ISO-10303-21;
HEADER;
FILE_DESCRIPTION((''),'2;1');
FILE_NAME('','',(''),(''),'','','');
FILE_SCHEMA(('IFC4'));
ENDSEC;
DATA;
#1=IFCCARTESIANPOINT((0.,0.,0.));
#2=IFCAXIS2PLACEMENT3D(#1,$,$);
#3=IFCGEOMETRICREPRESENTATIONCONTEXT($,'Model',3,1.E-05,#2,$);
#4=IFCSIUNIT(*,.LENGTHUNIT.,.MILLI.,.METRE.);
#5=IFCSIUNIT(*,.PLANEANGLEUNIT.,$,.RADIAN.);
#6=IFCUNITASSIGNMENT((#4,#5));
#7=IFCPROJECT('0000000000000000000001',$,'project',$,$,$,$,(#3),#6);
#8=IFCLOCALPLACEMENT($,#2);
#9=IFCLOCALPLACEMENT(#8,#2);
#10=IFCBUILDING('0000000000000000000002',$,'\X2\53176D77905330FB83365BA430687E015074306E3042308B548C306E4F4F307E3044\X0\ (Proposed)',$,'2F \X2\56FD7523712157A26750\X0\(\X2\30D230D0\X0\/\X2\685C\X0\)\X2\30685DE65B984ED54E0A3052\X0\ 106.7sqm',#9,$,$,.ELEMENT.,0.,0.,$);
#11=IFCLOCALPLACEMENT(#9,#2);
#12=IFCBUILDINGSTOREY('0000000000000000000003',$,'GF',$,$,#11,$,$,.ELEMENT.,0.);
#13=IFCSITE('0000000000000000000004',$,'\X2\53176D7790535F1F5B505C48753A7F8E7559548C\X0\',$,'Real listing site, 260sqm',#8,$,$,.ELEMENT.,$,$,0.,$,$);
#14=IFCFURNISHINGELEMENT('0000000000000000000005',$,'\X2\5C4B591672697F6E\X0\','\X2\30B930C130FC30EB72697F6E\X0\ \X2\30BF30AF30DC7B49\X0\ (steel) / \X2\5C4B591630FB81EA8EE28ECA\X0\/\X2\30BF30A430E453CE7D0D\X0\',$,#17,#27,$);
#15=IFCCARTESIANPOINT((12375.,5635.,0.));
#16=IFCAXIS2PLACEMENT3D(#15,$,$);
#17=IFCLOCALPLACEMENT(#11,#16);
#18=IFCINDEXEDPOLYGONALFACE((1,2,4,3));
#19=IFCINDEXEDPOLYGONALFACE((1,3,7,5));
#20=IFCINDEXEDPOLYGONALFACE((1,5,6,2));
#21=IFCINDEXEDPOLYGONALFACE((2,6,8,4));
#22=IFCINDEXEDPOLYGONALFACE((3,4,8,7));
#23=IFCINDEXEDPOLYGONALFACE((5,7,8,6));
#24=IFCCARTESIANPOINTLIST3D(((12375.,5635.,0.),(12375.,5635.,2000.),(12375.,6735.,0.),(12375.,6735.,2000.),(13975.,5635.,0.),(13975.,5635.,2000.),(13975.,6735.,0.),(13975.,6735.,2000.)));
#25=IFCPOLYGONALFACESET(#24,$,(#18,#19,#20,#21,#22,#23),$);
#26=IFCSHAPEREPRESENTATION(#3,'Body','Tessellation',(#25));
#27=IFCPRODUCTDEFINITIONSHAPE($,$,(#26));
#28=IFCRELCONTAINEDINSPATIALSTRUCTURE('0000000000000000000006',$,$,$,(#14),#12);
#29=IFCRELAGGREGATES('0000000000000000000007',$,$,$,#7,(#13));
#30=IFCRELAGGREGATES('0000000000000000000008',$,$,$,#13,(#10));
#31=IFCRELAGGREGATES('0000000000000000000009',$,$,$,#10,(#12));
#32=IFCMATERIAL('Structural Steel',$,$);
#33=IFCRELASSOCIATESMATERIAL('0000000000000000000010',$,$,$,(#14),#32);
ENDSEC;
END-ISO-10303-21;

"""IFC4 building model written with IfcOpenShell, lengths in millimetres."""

from ifc_helpers import new_model, si_unit, frame, frame_2d, origin, place, context, project, spatial, rectangle, extrude, material, element, save


model = new_model("IFC4")

# Units and contexts
model_context = context("Model", 3, precision=1e-05, world=origin())
ifc_project = project(units=[si_unit("LENGTHUNIT", "METRE", prefix="MILLI"), si_unit("PLANEANGLEUNIT", "RADIAN")], contexts=[model_context])

# Site, building, storey
site_placement = place(None, origin())
site = spatial("IfcSite", under=ifc_project, at=site_placement, Name="北海道弟子屈町美留和", ObjectType="Real listing site, 260sqm", CompositionType="ELEMENT", RefElevation=0.0)
building_placement = place(site_placement, origin())
building = spatial("IfcBuilding", under=site, at=building_placement, Name="北海道・茶室と縁側のある和の住まい (Proposed)", ObjectType="2F 国産無垢材(ヒバ/桜)と左官仕上げ 106.7sqm", CompositionType="ELEMENT", ElevationOfRefHeight=0.0, ElevationOfTerrain=0.0)
storey_placement = place(building_placement, origin())
storey = spatial("IfcBuildingStorey", under=building, at=storey_placement, Name="GF", CompositionType="ELEMENT", Elevation=0.0)

# Shared definitions
ifc_material_1 = material(Name="Structural Steel")

# Furnishing element
furnishing_1_placement = place(storey_placement, frame((12375.0, 5635.0, 0.0)))
element("IfcFurnishingElement", 1, at=furnishing_1_placement, inside=storey, material=ifc_material_1, Name="屋外物置", Description="スチール物置 タクボ等 (steel) / 屋外・自転車/タイヤ収納", context=model_context, shape_type="SweptSolid", body=[
    extrude(rectangle(XDim=1600.0, YDim=1100.0, at=frame_2d((800.0, 550.0))), frame((12375.0, 5635.0, 0.0)), (0.0, 0.0, 1.0), 2000.0),
])

save(model, "model.ifc")
